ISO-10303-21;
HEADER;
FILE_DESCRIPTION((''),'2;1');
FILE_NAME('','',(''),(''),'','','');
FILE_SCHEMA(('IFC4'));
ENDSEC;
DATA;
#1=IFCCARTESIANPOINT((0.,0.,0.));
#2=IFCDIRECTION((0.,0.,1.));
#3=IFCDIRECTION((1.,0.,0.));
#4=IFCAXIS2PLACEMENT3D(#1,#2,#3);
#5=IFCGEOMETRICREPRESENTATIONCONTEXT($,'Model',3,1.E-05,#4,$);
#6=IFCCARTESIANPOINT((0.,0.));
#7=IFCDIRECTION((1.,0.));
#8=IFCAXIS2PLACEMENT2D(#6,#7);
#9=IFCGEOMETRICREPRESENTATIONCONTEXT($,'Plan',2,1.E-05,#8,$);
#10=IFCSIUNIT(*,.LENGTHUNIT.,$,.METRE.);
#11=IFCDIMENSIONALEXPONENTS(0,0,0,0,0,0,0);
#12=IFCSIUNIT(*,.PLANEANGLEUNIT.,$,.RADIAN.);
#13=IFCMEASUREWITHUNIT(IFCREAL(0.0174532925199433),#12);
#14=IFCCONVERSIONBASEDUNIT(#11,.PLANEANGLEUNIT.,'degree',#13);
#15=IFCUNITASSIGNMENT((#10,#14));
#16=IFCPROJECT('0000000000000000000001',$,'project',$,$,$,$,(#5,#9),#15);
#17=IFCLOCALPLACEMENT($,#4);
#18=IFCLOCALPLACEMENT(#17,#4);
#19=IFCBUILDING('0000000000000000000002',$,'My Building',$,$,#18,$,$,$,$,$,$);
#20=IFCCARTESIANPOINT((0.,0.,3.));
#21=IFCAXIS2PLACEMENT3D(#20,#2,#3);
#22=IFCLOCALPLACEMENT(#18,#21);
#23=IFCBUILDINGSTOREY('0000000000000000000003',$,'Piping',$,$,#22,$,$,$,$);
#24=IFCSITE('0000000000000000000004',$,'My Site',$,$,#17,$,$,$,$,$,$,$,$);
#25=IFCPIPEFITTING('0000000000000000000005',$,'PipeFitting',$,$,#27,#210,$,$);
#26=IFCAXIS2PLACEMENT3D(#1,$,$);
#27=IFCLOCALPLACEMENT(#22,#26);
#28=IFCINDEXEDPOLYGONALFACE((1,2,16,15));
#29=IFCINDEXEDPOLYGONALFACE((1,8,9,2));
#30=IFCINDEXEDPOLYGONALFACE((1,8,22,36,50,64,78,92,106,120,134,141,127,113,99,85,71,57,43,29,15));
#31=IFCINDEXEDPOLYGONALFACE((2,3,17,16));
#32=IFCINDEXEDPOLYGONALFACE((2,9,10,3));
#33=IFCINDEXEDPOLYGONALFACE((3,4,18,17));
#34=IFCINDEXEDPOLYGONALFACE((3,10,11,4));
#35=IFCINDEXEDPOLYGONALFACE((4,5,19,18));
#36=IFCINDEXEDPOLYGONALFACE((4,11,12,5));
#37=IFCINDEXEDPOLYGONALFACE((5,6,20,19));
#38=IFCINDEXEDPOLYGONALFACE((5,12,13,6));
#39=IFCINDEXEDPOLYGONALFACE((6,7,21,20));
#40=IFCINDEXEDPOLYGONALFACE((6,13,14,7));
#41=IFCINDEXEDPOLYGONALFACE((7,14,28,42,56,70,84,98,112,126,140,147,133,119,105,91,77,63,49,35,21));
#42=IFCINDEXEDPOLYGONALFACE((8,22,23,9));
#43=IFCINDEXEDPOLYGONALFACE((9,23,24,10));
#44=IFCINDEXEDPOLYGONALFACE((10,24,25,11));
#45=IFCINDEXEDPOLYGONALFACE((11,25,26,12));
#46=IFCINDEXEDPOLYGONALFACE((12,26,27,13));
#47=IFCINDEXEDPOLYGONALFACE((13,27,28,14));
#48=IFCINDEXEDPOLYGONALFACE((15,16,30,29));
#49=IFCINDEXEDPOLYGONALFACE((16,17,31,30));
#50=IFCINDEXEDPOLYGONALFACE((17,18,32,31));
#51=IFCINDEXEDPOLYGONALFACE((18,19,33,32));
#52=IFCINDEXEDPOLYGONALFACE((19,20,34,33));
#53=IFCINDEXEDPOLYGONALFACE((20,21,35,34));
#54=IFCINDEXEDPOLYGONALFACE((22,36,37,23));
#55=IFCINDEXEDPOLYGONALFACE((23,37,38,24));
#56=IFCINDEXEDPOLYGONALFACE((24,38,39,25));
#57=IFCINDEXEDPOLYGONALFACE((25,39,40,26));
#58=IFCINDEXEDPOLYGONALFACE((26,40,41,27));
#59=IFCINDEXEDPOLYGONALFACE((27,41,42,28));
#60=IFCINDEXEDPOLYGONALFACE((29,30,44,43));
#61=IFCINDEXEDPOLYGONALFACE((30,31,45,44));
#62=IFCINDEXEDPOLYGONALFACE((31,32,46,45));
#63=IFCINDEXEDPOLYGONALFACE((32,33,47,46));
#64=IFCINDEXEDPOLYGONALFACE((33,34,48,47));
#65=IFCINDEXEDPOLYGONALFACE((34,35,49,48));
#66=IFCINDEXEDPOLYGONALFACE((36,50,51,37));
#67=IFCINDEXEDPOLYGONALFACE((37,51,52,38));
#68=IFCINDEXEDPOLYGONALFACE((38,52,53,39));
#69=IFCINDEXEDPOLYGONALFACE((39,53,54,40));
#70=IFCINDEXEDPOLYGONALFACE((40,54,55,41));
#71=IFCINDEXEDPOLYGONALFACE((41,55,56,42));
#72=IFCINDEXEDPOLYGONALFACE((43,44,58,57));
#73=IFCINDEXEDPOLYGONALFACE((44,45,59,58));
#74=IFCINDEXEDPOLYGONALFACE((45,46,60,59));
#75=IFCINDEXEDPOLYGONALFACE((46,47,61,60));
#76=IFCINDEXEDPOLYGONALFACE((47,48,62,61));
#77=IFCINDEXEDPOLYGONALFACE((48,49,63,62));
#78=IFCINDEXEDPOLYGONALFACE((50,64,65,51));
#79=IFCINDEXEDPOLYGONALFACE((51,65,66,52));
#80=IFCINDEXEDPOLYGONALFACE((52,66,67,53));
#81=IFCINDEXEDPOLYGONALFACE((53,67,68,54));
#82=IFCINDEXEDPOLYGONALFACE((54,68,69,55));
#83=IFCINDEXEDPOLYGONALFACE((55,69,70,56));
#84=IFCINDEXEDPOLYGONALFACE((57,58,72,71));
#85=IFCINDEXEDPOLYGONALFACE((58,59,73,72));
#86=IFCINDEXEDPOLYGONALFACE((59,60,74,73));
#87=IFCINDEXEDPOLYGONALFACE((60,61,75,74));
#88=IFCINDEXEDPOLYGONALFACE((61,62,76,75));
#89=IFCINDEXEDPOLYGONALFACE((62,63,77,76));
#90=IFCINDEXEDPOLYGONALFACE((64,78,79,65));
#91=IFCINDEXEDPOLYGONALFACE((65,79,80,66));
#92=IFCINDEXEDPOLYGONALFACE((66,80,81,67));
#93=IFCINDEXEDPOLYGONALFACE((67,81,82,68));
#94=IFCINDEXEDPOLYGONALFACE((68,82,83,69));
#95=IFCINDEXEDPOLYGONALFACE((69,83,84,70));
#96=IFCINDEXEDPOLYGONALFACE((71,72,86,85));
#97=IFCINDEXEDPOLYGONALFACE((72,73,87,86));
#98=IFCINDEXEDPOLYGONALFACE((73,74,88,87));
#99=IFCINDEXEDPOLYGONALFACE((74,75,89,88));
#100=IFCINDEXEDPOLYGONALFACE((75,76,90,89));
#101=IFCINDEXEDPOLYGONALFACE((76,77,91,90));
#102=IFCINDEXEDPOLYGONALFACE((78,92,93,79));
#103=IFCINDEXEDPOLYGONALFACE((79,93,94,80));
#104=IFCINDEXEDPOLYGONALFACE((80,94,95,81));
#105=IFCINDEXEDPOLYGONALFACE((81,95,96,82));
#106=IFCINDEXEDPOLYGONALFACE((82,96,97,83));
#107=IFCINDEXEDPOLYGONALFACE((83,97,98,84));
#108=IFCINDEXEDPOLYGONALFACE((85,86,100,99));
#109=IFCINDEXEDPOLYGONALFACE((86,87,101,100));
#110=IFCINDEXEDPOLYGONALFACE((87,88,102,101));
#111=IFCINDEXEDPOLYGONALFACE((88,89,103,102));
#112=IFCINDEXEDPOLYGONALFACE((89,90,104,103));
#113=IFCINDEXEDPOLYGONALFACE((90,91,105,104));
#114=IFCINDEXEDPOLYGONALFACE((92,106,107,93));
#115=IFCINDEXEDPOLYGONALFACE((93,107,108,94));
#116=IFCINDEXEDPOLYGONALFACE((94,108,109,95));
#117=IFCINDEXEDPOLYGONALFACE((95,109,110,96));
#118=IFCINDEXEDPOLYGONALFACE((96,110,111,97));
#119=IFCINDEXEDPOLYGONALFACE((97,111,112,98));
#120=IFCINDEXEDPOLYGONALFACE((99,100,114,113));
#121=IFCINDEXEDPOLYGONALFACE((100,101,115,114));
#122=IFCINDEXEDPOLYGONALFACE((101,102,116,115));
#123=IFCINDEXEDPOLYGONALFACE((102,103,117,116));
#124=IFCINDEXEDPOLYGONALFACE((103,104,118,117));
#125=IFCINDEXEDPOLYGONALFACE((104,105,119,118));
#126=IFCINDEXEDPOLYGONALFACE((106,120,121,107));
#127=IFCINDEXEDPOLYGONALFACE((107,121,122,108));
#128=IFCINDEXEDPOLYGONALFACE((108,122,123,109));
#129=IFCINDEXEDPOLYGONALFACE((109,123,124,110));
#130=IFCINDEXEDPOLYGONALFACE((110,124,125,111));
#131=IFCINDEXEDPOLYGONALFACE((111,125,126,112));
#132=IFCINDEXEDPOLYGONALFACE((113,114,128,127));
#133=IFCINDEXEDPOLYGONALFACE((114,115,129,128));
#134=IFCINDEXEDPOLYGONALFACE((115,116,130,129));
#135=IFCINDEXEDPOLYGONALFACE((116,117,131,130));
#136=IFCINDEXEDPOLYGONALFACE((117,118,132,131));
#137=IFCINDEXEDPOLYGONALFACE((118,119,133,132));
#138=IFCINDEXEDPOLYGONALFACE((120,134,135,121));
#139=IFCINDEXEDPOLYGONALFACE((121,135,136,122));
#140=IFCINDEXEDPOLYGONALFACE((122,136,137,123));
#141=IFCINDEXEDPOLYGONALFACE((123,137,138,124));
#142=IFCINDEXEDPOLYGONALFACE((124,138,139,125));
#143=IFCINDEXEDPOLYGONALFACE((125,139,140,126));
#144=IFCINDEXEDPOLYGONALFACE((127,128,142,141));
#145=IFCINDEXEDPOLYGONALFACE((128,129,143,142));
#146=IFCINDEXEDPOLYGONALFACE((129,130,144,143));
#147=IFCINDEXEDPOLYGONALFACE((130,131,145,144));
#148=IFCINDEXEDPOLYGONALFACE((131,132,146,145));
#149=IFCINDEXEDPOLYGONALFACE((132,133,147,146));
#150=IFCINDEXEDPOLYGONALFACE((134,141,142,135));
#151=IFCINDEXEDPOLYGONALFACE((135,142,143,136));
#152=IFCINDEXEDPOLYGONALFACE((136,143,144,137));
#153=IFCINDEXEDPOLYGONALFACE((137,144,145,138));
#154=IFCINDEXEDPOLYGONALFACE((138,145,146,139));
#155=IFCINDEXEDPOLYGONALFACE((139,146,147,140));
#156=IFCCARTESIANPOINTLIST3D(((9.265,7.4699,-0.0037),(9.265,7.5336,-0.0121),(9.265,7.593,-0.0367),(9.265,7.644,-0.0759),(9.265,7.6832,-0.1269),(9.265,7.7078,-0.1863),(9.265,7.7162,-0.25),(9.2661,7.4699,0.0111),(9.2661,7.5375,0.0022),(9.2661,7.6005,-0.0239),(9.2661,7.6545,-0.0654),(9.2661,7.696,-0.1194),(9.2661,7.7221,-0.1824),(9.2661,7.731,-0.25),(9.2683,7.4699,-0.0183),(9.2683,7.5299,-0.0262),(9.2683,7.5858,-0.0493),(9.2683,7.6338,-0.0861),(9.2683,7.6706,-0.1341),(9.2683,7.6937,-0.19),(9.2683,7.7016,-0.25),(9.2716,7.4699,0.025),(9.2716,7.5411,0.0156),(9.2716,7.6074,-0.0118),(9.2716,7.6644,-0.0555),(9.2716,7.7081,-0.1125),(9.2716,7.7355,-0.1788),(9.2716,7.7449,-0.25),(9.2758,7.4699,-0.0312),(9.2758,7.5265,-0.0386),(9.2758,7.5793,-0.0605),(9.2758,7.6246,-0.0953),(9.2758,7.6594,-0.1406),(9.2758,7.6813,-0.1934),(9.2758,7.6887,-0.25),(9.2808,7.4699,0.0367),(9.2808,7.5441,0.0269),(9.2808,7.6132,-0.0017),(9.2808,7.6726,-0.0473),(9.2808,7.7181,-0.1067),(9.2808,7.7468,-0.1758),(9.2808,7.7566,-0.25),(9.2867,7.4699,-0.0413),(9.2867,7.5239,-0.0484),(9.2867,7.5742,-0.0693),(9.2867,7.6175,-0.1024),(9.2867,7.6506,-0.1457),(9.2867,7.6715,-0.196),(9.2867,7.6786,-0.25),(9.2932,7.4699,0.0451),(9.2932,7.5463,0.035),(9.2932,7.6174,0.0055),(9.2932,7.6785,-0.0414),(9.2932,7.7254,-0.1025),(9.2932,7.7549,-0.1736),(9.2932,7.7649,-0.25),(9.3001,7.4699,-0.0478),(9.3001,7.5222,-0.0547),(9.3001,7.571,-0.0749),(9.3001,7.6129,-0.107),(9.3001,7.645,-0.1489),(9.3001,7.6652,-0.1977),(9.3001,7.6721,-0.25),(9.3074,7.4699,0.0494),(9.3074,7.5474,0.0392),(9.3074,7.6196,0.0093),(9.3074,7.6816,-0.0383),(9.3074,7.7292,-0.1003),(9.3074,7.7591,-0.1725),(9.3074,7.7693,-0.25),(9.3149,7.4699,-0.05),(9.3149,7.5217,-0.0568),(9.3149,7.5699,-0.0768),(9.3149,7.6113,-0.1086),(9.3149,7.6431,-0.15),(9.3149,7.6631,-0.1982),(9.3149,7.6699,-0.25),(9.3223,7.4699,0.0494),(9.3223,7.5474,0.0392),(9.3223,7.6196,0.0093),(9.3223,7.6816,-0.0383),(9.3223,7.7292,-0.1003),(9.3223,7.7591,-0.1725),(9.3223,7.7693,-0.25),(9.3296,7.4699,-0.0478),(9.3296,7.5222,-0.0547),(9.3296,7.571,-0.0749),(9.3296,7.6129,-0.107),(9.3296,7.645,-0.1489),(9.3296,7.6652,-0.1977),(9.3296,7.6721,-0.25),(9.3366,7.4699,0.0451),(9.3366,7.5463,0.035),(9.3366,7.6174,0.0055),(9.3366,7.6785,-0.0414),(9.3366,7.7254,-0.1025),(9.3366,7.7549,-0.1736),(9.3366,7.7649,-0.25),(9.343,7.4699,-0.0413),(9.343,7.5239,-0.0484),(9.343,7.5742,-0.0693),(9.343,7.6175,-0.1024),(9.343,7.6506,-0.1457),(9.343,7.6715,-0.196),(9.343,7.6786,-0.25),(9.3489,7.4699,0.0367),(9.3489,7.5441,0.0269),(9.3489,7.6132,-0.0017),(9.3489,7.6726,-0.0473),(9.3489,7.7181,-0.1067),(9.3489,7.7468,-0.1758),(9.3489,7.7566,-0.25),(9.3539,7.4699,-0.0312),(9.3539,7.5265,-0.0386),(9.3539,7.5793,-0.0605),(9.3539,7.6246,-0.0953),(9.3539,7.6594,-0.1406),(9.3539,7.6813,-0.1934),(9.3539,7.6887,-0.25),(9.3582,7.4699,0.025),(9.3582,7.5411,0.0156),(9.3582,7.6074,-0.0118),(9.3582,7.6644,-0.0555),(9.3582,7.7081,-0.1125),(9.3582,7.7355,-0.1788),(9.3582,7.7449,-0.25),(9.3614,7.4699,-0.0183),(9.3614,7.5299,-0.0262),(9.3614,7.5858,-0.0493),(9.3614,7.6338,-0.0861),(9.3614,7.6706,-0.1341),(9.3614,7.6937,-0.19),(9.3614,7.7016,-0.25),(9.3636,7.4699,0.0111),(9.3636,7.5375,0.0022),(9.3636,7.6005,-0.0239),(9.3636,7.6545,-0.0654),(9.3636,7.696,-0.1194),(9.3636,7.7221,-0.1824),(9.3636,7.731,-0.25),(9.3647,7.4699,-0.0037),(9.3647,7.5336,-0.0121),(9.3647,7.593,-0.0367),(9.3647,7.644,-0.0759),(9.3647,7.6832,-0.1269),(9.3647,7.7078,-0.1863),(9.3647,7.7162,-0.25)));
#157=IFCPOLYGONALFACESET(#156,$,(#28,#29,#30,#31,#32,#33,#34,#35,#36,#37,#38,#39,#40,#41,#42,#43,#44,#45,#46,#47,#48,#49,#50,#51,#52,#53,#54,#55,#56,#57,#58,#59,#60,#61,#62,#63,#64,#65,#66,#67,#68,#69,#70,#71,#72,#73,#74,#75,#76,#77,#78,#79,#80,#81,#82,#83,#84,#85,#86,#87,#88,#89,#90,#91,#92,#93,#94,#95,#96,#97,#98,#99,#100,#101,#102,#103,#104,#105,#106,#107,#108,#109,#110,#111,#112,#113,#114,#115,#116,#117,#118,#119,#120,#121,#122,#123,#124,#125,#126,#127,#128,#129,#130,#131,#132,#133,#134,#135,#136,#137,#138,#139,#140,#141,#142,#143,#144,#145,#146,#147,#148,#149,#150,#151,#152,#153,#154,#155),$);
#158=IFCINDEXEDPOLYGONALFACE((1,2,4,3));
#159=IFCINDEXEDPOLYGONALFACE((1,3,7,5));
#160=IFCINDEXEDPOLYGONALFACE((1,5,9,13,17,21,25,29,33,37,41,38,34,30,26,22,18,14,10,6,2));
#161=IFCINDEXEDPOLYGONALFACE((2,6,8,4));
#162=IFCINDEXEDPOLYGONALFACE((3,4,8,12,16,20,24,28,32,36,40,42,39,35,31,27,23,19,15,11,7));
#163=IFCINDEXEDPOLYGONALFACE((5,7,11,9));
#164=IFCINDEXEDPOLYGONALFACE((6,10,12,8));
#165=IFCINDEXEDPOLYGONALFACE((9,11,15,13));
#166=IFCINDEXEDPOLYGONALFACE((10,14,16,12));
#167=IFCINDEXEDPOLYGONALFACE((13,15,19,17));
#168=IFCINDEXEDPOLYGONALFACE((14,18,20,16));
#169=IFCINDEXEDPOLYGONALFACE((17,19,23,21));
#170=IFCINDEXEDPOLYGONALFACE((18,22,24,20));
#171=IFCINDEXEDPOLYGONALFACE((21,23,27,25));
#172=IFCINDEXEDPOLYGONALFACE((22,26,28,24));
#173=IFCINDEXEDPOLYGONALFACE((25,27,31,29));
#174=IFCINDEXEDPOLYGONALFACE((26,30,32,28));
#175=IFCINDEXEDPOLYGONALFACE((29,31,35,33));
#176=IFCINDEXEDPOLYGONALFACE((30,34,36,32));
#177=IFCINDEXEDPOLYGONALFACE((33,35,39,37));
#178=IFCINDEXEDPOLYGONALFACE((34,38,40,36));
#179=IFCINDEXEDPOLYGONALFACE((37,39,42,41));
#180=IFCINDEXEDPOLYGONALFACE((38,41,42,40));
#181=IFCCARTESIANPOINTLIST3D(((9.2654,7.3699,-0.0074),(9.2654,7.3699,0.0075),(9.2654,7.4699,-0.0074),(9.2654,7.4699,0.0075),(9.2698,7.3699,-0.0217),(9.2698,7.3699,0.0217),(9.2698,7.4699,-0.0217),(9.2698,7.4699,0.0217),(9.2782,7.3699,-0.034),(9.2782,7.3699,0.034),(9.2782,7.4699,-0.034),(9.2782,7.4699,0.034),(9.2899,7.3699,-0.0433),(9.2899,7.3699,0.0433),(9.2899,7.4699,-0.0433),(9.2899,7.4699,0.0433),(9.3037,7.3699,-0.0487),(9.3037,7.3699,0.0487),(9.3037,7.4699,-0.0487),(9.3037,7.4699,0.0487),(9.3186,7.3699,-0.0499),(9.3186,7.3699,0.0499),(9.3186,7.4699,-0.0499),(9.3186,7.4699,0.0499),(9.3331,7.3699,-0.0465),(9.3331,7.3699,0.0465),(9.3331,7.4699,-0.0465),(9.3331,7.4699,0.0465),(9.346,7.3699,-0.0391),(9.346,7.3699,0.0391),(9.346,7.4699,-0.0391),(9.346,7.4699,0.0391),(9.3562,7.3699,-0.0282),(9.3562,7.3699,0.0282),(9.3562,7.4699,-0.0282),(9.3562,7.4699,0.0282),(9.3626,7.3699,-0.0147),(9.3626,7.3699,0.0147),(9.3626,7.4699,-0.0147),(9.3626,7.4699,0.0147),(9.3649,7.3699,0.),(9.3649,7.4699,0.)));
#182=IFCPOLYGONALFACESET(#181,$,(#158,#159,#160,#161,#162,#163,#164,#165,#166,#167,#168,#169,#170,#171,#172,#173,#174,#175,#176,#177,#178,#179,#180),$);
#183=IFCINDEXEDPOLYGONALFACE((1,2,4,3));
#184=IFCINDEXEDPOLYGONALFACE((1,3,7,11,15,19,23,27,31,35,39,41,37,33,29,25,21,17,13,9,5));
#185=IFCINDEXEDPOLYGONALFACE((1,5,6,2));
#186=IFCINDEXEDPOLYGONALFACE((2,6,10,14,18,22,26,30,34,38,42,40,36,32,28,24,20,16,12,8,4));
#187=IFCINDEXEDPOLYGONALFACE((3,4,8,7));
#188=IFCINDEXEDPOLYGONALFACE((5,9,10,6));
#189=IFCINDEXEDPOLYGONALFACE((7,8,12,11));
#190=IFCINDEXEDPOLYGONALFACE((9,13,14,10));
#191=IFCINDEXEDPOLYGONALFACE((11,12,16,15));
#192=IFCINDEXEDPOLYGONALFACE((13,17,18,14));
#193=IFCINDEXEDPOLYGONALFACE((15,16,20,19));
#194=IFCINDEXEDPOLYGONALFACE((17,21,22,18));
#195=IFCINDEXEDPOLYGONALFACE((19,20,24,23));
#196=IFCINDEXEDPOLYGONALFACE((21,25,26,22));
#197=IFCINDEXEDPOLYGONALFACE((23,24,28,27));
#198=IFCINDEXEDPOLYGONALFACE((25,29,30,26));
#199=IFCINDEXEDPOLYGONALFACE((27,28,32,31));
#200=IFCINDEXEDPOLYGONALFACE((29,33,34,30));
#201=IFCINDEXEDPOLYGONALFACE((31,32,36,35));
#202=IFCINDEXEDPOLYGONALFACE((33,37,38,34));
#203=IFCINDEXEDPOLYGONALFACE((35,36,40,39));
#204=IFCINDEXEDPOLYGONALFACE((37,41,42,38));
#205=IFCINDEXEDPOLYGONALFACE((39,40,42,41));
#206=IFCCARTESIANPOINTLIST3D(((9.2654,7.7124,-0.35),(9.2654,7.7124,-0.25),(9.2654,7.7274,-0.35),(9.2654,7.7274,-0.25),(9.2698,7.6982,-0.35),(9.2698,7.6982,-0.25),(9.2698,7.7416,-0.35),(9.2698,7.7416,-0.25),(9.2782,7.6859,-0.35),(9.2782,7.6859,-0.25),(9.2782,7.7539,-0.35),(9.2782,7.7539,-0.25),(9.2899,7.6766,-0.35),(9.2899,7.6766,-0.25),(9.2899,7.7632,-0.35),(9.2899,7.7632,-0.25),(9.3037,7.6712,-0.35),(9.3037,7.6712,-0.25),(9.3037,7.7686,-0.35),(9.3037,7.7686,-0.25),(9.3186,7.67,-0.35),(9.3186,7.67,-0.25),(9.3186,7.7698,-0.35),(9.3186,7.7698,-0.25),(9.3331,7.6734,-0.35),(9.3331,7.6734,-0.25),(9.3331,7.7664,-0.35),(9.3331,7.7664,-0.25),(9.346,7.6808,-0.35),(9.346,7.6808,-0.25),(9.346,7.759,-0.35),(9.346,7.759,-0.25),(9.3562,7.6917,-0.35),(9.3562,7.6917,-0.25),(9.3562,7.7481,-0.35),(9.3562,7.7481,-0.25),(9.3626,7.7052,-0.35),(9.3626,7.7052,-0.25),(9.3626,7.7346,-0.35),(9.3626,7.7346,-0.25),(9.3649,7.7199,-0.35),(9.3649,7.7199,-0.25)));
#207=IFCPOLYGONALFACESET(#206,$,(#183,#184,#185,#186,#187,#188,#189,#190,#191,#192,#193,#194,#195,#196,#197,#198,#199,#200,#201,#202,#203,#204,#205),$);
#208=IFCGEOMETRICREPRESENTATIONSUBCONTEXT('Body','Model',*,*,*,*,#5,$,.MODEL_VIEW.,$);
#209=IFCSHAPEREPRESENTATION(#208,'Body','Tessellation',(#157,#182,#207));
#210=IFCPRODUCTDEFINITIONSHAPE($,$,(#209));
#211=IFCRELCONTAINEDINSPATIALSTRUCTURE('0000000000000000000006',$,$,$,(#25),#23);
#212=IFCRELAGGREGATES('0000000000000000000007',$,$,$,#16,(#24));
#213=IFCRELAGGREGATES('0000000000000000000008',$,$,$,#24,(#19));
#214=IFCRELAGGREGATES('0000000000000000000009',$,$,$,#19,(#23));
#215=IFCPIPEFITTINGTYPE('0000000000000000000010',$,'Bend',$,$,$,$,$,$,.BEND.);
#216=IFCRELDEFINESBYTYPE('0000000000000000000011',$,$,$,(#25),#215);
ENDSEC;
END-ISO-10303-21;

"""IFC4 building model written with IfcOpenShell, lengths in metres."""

from ifc_helpers import new_model, entity, si_unit, converted_unit, frame, origin_with_axes, origin_2d_with_axis, place, context, subcontext, project, spatial, circle, extrude, source, transform, mapped, type_object, type_shapes, element, save


model = new_model("IFC4")

# Units and contexts
model_context = context("Model", 3, precision=1e-05, world=origin_with_axes())
plan_context = context("Plan", 2, precision=1e-05, world=origin_2d_with_axis())
body_context = subcontext(model_context, "Body", "Model", "MODEL_VIEW")
ifc_project = project(units=[si_unit("LENGTHUNIT", "METRE"), converted_unit("PLANEANGLEUNIT", "degree", entity("IfcReal", 0.0174532925199433), si_unit("PLANEANGLEUNIT", "RADIAN"), dimensions=[0, 0, 0, 0, 0, 0, 0])], contexts=[model_context, plan_context])

# Site, building, storey
site_placement = place(None, origin_with_axes())
site = spatial("IfcSite", under=ifc_project, at=site_placement, Name="My Site")
building_placement = place(site_placement, origin_with_axes())
building = spatial("IfcBuilding", under=site, at=building_placement, Name="My Building")
storey_placement = place(building_placement, frame((0.0, 0.0, 3.0), z_axis=(0.0, 0.0, 1.0), x_axis=(1.0, 0.0, 0.0)))
storey = spatial("IfcBuildingStorey", under=building, at=storey_placement, Name="Piping")

# Pipe fitting
pipe_fitting_type = type_object("IfcPipeFittingType", Name="Bend", PredefinedType="BEND")
shared_shape = source(origin_with_axes(), body_context, "Body", "SolidModel", [
    entity("IfcSweptDiskSolid", entity("IfcIndexedPolyCurve", entity("IfcCartesianPointList3D", [[0.0, 0.0, -0.1], [0.0, -0.0732, -0.2768], [0.0, -0.25, -0.35]]), [entity("IfcArcIndex", [1, 2, 3])]), 0.05),
    extrude(circle(Radius=0.05), origin_with_axes(), (0.0, 0.0, -1.0), 0.1),
    extrude(circle(Radius=0.05), frame((0.0, -0.25, -0.35), z_axis=(0.0, -1.0, 0.0), x_axis=(1.0, 0.0, 0.0)), (0.0, 0.0, 1.0), 0.1),
])
type_shapes(pipe_fitting_type, [shared_shape])
for number, where, z_axis, x_axis, name in (
    (1, (9.3149, 7.3699, 0.0), (0.0, -1.0, 0.0), (1.0, 0.0, 0.0), "PipeFitting"),
):
    element("IfcPipeFitting", number, at=place(storey_placement, frame(where, z_axis=z_axis, x_axis=x_axis)), inside=storey, type_object=pipe_fitting_type, Name=name, context=body_context, shape_type="MappedRepresentation", body=[
        mapped(shared_shape, transform((0.0, 0.0, 0.0), x_axis=(1.0, 0.0, 0.0), y_axis=(0.0, 1.0, 0.0), z_axis=(0.0, 0.0, 1.0), scale=1.0)),
    ])

save(model, "model.ifc")
